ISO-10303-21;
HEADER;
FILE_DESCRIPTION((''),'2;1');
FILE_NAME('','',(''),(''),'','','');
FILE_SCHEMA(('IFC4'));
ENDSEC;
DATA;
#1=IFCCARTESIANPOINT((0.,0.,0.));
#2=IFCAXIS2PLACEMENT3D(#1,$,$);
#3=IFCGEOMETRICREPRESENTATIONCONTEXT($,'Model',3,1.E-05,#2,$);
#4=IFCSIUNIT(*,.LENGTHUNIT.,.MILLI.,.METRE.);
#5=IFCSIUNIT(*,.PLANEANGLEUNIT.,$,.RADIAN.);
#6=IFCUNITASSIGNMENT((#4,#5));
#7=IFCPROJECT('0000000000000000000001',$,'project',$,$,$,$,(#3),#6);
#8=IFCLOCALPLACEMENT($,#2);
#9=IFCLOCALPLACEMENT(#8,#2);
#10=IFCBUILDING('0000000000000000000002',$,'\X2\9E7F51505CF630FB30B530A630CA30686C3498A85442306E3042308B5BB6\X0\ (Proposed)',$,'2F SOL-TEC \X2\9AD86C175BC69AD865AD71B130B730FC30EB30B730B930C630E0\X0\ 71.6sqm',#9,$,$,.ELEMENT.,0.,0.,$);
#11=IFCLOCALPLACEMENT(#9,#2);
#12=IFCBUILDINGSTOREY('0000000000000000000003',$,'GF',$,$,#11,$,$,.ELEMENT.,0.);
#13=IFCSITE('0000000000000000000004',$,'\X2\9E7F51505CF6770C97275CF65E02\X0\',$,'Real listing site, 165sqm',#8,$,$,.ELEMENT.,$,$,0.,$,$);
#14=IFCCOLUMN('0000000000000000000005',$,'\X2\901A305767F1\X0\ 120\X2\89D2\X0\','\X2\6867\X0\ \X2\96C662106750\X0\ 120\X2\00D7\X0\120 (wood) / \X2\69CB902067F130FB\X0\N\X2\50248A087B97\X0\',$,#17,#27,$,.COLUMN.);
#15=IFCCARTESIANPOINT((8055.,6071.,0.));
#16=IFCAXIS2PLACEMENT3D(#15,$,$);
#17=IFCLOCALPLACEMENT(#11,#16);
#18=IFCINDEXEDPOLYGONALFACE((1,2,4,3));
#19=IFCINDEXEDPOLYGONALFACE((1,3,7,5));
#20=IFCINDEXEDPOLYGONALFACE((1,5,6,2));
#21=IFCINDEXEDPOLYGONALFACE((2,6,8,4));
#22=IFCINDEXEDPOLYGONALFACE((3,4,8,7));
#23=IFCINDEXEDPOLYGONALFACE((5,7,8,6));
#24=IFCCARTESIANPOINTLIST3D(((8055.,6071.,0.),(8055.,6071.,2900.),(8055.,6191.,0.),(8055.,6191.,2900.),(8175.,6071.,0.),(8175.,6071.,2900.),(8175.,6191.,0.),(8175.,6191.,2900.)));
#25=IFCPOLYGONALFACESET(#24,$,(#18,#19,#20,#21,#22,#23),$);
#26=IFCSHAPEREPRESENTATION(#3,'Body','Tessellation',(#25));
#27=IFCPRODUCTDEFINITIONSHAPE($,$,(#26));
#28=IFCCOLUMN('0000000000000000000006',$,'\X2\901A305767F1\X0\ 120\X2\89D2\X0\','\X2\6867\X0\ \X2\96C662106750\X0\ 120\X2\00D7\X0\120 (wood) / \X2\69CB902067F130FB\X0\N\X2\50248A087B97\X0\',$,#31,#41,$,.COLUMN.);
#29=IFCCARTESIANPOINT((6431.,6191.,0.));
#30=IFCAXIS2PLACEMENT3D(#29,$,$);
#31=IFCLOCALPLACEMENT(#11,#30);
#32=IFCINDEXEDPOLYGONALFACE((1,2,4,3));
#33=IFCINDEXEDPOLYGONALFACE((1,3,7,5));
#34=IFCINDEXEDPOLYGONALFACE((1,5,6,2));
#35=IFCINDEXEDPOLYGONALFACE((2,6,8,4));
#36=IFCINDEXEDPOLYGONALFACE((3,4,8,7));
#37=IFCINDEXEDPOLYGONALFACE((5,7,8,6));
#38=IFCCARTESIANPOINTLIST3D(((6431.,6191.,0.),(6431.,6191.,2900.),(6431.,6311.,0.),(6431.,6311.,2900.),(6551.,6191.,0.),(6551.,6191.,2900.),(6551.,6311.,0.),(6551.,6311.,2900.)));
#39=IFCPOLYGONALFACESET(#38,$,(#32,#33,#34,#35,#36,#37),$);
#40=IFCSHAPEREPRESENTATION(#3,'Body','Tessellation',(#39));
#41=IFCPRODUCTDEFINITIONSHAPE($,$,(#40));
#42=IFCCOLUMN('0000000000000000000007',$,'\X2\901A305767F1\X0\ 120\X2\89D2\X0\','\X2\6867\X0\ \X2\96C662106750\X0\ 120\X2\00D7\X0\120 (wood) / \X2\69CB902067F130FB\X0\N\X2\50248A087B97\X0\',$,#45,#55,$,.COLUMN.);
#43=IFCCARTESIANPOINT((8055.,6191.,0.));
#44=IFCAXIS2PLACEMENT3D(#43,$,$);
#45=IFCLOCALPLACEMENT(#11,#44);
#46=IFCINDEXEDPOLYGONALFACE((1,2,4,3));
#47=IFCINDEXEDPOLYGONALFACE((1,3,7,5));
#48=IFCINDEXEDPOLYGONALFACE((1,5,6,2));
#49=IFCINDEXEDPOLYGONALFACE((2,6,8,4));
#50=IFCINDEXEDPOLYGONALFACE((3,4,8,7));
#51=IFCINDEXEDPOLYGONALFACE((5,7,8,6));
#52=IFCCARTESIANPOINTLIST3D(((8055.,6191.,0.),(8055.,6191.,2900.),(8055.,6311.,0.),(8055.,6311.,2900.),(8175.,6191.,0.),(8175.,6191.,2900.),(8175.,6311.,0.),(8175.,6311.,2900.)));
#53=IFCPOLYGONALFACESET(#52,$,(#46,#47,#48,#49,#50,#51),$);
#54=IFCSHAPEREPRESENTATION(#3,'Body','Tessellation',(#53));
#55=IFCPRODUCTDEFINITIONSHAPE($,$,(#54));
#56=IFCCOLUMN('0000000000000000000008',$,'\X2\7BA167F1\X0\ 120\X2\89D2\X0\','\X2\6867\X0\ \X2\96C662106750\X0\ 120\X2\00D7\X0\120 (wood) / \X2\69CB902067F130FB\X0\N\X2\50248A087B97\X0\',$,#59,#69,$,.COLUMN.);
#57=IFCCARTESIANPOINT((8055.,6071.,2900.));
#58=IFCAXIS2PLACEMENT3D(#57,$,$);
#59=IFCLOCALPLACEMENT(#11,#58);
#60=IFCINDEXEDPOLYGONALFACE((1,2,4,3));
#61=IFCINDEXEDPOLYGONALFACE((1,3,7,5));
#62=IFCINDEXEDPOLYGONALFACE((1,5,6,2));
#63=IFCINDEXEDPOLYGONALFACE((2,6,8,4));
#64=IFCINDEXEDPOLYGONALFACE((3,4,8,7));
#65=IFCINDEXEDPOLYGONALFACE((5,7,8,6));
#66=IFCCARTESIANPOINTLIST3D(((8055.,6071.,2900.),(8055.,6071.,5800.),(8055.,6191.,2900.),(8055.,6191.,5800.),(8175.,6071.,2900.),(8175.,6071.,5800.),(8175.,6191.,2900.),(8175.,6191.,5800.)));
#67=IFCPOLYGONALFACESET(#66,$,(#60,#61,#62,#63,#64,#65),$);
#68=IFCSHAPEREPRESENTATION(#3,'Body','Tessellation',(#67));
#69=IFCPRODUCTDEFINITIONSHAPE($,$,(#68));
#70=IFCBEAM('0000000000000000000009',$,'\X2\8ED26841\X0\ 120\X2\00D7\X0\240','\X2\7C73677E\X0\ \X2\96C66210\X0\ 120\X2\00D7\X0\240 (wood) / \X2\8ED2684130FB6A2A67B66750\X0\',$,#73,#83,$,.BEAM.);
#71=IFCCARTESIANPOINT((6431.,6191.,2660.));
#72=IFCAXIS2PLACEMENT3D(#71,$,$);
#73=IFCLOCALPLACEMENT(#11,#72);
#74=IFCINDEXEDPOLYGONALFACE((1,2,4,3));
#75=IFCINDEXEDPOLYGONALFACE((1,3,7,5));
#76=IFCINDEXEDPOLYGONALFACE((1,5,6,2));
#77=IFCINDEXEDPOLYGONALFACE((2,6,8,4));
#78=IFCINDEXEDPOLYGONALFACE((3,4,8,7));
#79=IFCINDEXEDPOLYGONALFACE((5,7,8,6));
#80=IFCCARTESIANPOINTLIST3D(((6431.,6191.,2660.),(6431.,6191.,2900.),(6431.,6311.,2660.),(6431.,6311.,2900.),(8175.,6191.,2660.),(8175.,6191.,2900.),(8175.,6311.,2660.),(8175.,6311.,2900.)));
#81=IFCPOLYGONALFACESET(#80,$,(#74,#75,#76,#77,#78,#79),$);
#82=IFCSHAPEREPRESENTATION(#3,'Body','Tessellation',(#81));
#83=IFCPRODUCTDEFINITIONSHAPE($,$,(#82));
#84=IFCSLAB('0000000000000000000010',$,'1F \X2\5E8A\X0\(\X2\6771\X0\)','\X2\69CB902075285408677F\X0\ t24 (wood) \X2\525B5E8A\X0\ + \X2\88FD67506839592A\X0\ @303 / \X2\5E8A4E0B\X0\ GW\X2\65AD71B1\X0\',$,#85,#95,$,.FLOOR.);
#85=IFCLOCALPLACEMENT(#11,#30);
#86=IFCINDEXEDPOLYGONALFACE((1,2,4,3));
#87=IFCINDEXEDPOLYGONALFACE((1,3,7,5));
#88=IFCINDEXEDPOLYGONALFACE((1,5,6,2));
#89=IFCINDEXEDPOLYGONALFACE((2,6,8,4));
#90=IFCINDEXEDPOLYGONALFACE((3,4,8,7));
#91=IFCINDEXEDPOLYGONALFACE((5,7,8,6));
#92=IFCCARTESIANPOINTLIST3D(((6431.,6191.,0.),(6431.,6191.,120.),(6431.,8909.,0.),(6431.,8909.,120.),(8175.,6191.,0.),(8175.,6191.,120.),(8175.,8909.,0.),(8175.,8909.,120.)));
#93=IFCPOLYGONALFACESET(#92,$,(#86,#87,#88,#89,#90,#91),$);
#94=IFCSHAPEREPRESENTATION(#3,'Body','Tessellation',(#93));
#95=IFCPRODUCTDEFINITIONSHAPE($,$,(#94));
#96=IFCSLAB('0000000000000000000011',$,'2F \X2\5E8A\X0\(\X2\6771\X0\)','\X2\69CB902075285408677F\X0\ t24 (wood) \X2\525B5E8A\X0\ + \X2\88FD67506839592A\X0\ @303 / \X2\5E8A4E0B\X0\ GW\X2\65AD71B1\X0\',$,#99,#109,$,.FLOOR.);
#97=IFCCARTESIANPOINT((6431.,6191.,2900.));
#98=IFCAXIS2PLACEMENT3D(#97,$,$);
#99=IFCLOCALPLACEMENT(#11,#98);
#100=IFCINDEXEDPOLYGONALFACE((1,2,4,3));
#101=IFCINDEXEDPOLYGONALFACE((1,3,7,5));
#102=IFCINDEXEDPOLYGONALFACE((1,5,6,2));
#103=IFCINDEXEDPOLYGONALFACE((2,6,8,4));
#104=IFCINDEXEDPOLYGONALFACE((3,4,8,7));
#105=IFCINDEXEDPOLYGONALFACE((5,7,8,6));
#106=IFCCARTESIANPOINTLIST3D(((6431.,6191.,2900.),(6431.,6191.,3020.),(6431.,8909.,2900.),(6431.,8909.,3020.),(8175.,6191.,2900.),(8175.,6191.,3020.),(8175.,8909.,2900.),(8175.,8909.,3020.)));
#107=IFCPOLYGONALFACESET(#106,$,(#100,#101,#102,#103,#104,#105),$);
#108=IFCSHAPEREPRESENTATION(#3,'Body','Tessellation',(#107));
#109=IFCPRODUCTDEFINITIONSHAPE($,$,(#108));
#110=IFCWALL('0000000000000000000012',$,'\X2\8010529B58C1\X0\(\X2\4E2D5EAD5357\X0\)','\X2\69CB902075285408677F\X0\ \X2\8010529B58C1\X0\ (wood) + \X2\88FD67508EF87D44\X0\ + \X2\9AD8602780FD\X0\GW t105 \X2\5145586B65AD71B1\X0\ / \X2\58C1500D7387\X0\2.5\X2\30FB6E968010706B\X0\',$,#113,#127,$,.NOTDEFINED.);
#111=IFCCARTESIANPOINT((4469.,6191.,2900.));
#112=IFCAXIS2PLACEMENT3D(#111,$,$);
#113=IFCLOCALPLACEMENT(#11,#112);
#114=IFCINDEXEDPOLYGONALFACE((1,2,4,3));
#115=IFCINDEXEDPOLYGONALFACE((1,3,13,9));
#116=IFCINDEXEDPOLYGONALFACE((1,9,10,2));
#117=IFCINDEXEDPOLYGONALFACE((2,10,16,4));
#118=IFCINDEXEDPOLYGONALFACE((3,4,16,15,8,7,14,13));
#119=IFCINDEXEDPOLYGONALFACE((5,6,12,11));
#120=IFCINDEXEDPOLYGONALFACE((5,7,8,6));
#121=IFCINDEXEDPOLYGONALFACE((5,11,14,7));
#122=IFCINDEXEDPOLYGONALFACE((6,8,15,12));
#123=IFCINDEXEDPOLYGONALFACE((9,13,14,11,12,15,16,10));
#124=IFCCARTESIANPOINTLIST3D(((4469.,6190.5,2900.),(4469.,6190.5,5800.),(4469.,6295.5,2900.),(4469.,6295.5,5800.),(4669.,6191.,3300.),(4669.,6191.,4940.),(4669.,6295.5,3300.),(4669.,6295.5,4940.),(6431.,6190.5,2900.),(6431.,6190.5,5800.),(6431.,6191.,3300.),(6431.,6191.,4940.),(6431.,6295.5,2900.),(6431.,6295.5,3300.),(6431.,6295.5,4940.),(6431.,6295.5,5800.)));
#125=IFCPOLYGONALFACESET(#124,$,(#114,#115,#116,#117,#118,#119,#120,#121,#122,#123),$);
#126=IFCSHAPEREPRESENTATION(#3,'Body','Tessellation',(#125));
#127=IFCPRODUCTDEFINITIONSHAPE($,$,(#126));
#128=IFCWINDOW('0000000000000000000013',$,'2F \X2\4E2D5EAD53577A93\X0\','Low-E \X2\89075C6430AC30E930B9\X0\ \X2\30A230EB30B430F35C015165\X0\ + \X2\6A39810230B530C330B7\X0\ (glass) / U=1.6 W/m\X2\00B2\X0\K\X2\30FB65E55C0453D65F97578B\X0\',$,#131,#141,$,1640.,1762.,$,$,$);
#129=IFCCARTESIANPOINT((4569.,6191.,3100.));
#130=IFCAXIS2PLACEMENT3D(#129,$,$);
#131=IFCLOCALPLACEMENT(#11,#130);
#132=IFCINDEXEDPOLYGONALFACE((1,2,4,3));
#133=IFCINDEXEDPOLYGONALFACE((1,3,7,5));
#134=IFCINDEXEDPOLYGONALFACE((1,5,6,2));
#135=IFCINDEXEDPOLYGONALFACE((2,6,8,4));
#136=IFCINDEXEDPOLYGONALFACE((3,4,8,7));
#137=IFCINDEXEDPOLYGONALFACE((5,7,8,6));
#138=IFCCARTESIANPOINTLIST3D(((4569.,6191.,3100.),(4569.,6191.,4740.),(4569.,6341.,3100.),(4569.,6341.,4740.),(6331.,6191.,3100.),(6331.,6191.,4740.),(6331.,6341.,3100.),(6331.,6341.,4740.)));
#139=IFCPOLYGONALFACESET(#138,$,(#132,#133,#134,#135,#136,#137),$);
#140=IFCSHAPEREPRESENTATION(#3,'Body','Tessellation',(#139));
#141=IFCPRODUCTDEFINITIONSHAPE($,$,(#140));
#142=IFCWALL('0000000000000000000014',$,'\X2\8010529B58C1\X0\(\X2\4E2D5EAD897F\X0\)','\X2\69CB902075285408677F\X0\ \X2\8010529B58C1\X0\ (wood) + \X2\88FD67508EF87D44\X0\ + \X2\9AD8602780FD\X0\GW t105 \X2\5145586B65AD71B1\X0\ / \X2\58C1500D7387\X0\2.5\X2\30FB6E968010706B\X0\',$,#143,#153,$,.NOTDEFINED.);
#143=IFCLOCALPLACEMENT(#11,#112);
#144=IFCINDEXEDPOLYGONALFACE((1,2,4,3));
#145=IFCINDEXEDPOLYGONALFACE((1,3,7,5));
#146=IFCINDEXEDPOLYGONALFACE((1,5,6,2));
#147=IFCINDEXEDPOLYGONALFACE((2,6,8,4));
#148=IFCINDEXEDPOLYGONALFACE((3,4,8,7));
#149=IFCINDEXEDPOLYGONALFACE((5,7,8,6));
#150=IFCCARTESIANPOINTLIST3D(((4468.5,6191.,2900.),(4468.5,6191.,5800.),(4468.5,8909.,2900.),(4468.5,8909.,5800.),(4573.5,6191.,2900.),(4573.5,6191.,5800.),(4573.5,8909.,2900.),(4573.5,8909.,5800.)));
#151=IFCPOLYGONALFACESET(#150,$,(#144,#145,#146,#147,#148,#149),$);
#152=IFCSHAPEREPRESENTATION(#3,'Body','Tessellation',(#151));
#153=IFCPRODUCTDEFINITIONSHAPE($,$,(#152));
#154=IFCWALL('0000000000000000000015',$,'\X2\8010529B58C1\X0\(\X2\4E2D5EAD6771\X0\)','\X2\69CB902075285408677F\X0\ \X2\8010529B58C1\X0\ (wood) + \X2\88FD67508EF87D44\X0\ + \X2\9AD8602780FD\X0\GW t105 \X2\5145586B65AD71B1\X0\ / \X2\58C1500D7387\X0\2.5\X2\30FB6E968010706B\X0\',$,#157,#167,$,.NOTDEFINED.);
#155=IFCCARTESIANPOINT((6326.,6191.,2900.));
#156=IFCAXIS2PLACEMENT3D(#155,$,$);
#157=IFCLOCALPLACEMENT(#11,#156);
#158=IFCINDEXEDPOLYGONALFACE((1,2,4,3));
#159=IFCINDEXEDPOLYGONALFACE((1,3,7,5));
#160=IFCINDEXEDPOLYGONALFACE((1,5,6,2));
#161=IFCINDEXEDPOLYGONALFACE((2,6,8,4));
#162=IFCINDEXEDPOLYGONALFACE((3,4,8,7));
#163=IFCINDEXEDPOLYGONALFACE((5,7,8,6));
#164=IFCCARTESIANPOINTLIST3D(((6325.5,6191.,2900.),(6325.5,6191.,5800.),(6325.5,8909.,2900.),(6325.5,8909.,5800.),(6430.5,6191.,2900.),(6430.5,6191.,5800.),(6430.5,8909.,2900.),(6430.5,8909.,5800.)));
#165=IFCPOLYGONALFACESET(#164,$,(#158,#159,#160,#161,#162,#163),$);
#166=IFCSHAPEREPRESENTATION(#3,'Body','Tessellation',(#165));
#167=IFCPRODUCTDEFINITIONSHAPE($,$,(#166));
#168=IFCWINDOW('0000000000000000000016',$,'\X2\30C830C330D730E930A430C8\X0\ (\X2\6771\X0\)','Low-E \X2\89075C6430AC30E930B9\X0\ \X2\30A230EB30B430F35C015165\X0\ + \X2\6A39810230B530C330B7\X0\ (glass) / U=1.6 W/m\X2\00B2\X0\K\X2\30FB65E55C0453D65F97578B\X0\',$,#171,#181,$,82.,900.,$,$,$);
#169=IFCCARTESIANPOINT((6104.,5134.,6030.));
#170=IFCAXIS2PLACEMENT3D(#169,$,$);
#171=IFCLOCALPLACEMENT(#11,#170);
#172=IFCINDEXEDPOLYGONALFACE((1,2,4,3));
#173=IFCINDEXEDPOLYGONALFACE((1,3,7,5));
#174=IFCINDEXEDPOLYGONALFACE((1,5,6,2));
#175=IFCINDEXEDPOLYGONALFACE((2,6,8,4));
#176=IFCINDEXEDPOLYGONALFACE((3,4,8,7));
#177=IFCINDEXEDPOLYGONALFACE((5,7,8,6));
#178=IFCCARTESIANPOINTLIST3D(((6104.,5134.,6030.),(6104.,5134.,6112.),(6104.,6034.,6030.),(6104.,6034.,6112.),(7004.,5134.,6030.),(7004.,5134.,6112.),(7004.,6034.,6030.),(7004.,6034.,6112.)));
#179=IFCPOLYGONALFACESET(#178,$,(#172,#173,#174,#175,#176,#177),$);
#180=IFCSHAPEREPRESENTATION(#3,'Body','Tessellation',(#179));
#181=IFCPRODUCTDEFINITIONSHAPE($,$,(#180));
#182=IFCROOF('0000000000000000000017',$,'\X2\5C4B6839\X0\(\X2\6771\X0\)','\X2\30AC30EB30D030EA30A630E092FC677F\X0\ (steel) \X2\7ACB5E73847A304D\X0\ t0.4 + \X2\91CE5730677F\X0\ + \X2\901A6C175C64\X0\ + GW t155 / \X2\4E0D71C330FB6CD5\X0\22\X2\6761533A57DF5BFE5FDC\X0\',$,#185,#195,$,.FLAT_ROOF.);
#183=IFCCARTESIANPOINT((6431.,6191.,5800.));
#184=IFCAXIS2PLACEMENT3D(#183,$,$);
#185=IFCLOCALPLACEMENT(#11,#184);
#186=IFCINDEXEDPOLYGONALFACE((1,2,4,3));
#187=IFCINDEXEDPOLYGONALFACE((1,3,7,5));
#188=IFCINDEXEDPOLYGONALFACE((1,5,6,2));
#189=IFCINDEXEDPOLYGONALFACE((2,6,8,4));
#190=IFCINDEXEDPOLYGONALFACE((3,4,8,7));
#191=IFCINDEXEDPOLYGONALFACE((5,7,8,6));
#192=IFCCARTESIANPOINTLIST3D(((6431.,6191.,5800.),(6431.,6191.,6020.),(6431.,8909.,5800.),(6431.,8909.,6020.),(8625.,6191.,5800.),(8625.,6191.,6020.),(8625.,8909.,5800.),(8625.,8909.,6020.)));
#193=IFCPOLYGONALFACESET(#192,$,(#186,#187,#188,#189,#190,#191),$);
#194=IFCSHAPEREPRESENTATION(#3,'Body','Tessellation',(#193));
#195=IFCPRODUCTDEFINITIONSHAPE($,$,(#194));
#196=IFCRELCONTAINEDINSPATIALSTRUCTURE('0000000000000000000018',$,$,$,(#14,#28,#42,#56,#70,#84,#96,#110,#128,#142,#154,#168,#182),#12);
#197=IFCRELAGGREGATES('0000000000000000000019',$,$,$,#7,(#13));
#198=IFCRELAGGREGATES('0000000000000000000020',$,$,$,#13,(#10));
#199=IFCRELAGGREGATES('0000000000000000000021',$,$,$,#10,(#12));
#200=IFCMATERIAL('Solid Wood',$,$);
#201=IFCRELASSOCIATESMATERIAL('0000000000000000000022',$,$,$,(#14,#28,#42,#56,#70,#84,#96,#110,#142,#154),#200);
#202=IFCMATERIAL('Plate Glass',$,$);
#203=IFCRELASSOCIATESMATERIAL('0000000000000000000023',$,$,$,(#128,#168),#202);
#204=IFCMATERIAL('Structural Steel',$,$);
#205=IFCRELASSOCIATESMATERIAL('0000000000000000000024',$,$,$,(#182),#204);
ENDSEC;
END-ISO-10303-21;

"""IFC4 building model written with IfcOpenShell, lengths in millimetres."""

from ifc_helpers import new_model, si_unit, frame, frame_2d, origin, place, context, project, spatial, rectangle, extrude, material, element, fill, save


model = new_model("IFC4")

# Units and contexts
model_context = context("Model", 3, precision=1e-05, world=origin())
ifc_project = project(units=[si_unit("LENGTHUNIT", "METRE", prefix="MILLI"), si_unit("PLANEANGLEUNIT", "RADIAN")], contexts=[model_context])

# Site, building, storey
site_placement = place(None, origin())
site = spatial("IfcSite", under=ifc_project, at=site_placement, Name="鹿児島県霧島市", ObjectType="Real listing site, 165sqm", CompositionType="ELEMENT", RefElevation=0.0)
building_placement = place(site_placement, origin())
building = spatial("IfcBuilding", under=site, at=building_placement, Name="鹿児島・サウナと水風呂のある家 (Proposed)", ObjectType="2F SOL-TEC 高気密高断熱シールシステム 71.6sqm", CompositionType="ELEMENT", ElevationOfRefHeight=0.0, ElevationOfTerrain=0.0)
storey_placement = place(building_placement, origin())
storey = spatial("IfcBuildingStorey", under=building, at=storey_placement, Name="GF", CompositionType="ELEMENT", Elevation=0.0)

# Columns
ifc_material_1 = material(Name="Solid Wood")
column_1_placement = place(storey_placement, frame((8055.0, 6071.0, 0.0)))
element("IfcColumn", 1, at=column_1_placement, inside=storey, material=ifc_material_1, Name="通し柱 120角", Description="桧 集成材 120×120 (wood) / 構造柱・N値計算", PredefinedType="COLUMN", context=model_context, shape_type="SweptSolid", body=[
    extrude(rectangle(XDim=120.0, YDim=120.0, at=frame_2d((60.0, 60.0))), frame((8055.0, 6071.0, 0.0)), (0.0, 0.0, 1.0), 2900.0),
])
column_2_placement = place(storey_placement, frame((6431.0, 6191.0, 0.0)))
element("IfcColumn", 2, at=column_2_placement, inside=storey, material=ifc_material_1, Name="通し柱 120角", Description="桧 集成材 120×120 (wood) / 構造柱・N値計算", PredefinedType="COLUMN", context=model_context, shape_type="SweptSolid", body=[
    extrude(rectangle(XDim=120.0, YDim=120.0, at=frame_2d((60.0, 60.0))), frame((6431.0, 6191.0, 0.0)), (0.0, 0.0, 1.0), 2900.0),
])
column_3_placement = place(storey_placement, frame((8055.0, 6191.0, 0.0)))
element("IfcColumn", 3, at=column_3_placement, inside=storey, material=ifc_material_1, Name="通し柱 120角", Description="桧 集成材 120×120 (wood) / 構造柱・N値計算", PredefinedType="COLUMN", context=model_context, shape_type="SweptSolid", body=[
    extrude(rectangle(XDim=120.0, YDim=120.0, at=frame_2d((60.0, 60.0))), frame((8055.0, 6191.0, 0.0)), (0.0, 0.0, 1.0), 2900.0),
])
column_4_placement = place(storey_placement, frame((8055.0, 6071.0, 2900.0)))
element("IfcColumn", 4, at=column_4_placement, inside=storey, material=ifc_material_1, Name="管柱 120角", Description="桧 集成材 120×120 (wood) / 構造柱・N値計算", PredefinedType="COLUMN", context=model_context, shape_type="SweptSolid", body=[
    extrude(rectangle(XDim=120.0, YDim=120.0, at=frame_2d((60.0, 60.0))), frame((8055.0, 6071.0, 2900.0)), (0.0, 0.0, 1.0), 2900.0),
])

# Beam
beam_1_placement = place(storey_placement, frame((6431.0, 6191.0, 2660.0)))
element("IfcBeam", 5, at=beam_1_placement, inside=storey, material=ifc_material_1, Name="軒桁 120×240", Description="米松 集成 120×240 (wood) / 軒桁・横架材", PredefinedType="BEAM", context=model_context, shape_type="SweptSolid", body=[
    extrude(rectangle(XDim=1744.0, YDim=120.0, at=frame_2d((872.0, 60.0))), frame((6431.0, 6191.0, 2660.0)), (0.0, 0.0, 1.0), 240.0),
])

# Slabs
slab_1_placement = place(storey_placement, frame((6431.0, 6191.0, 0.0)))
element("IfcSlab", 6, at=slab_1_placement, inside=storey, material=ifc_material_1, Name="1F 床(東)", Description="構造用合板 t24 (wood) 剛床 + 製材根太 @303 / 床下 GW断熱", PredefinedType="FLOOR", context=model_context, shape_type="SweptSolid", body=[
    extrude(rectangle(XDim=1744.0, YDim=2718.0, at=frame_2d((872.0, 1359.0))), frame((6431.0, 6191.0, 0.0)), (0.0, 0.0, 1.0), 120.0),
])
slab_2_placement = place(storey_placement, frame((6431.0, 6191.0, 2900.0)))
element("IfcSlab", 7, at=slab_2_placement, inside=storey, material=ifc_material_1, Name="2F 床(東)", Description="構造用合板 t24 (wood) 剛床 + 製材根太 @303 / 床下 GW断熱", PredefinedType="FLOOR", context=model_context, shape_type="SweptSolid", body=[
    extrude(rectangle(XDim=1744.0, YDim=2718.0, at=frame_2d((872.0, 1359.0))), frame((6431.0, 6191.0, 2900.0)), (0.0, 0.0, 1.0), 120.0),
])

# Wall, opening, window
wall_1_placement = place(storey_placement, frame((4469.0, 6191.0, 2900.0)))
wall_1 = element("IfcWall", 8, at=wall_1_placement, inside=storey, material=ifc_material_1, Name="耐力壁(中庭南)", Description="構造用合板 耐力壁 (wood) + 製材軸組 + 高性能GW t105 充填断熱 / 壁倍率2.5・準耐火", PredefinedType="NOTDEFINED", context=model_context, shape_type="SweptSolid", body=[
    extrude(rectangle(XDim=1962.0, YDim=105.0, at=frame_2d((981.0, 52.0))), frame((4469.0, 6191.0, 2900.0)), (0.0, 0.0, 1.0), 2900.0),
])
opening_placement = place(storey_placement, frame((4569.0, 6191.0, 3100.0)))
opening = element("IfcOpeningElement", 9, at=opening_placement, cuts=wall_1, PredefinedType="NOTDEFINED", context=model_context, shape_type="SweptSolid", body=[
    extrude(rectangle(XDim=1762.0, YDim=150.0, at=frame_2d((881.0, 75.0))), frame((4569.0, 6191.0, 3100.0)), (0.0, 0.0, 1.0), 1640.0),
])
ifc_material_2 = material(Name="Plate Glass")
window_1_placement = place(storey_placement, frame((4569.0, 6191.0, 3100.0)))
window_1 = element("IfcWindow", 10, at=window_1_placement, inside=storey, material=ifc_material_2, Name="2F 中庭南窓", Description="Low-E 複層ガラス アルゴン封入 + 樹脂サッシ (glass) / U=1.6 W/m²K・日射取得型", OverallHeight=1640.0, OverallWidth=1762.0, context=model_context, shape_type="SweptSolid", body=[
    extrude(rectangle(XDim=1762.0, YDim=150.0, at=frame_2d((881.0, 75.0))), frame((4569.0, 6191.0, 3100.0)), (0.0, 0.0, 1.0), 1640.0),
])
fill(opening, window_1)

# Walls
wall_2_placement = place(storey_placement, frame((4469.0, 6191.0, 2900.0)))
element("IfcWall", 11, at=wall_2_placement, inside=storey, material=ifc_material_1, Name="耐力壁(中庭西)", Description="構造用合板 耐力壁 (wood) + 製材軸組 + 高性能GW t105 充填断熱 / 壁倍率2.5・準耐火", PredefinedType="NOTDEFINED", context=model_context, shape_type="SweptSolid", body=[
    extrude(rectangle(XDim=105.0, YDim=2718.0, at=frame_2d((52.0, 1359.0))), frame((4469.0, 6191.0, 2900.0)), (0.0, 0.0, 1.0), 2900.0),
])
wall_3_placement = place(storey_placement, frame((6326.0, 6191.0, 2900.0)))
element("IfcWall", 12, at=wall_3_placement, inside=storey, material=ifc_material_1, Name="耐力壁(中庭東)", Description="構造用合板 耐力壁 (wood) + 製材軸組 + 高性能GW t105 充填断熱 / 壁倍率2.5・準耐火", PredefinedType="NOTDEFINED", context=model_context, shape_type="SweptSolid", body=[
    extrude(rectangle(XDim=105.0, YDim=2718.0, at=frame_2d((52.0, 1359.0))), frame((6326.0, 6191.0, 2900.0)), (0.0, 0.0, 1.0), 2900.0),
])

# Window
window_2_placement = place(storey_placement, frame((6104.0, 5134.0, 6030.0)))
element("IfcWindow", 13, at=window_2_placement, inside=storey, material=ifc_material_2, Name="トップライト (東)", Description="Low-E 複層ガラス アルゴン封入 + 樹脂サッシ (glass) / U=1.6 W/m²K・日射取得型", OverallHeight=82.0, OverallWidth=900.0, context=model_context, shape_type="SweptSolid", body=[
    extrude(rectangle(XDim=900.0, YDim=900.0, at=frame_2d((450.0, 450.0))), frame((6104.0, 5134.0, 6030.0)), (0.0, 0.0, 1.0), 82.0),
])

# Roof
ifc_material_3 = material(Name="Structural Steel")
for number, where, name in (
    (14, (6431.0, 6191.0, 5800.0), "屋根(東)"),
):
    element("IfcRoof", number, at=place(storey_placement, frame(where)), inside=storey, material=ifc_material_3, Name=name, Description="ガルバリウム鋼板 (steel) 立平葺き t0.4 + 野地板 + 通気層 + GW t155 / 不燃・法22条区域対応", PredefinedType="FLAT_ROOF", context=model_context, shape_type="SweptSolid", body=[
        extrude(rectangle(XDim=2194.0, YDim=2718.0, at=frame_2d((1097.0, 1359.0))), frame((6431.0, 6191.0, 5800.0)), (0.0, 0.0, 1.0), 220.0),
    ])

save(model, "model.ifc")
